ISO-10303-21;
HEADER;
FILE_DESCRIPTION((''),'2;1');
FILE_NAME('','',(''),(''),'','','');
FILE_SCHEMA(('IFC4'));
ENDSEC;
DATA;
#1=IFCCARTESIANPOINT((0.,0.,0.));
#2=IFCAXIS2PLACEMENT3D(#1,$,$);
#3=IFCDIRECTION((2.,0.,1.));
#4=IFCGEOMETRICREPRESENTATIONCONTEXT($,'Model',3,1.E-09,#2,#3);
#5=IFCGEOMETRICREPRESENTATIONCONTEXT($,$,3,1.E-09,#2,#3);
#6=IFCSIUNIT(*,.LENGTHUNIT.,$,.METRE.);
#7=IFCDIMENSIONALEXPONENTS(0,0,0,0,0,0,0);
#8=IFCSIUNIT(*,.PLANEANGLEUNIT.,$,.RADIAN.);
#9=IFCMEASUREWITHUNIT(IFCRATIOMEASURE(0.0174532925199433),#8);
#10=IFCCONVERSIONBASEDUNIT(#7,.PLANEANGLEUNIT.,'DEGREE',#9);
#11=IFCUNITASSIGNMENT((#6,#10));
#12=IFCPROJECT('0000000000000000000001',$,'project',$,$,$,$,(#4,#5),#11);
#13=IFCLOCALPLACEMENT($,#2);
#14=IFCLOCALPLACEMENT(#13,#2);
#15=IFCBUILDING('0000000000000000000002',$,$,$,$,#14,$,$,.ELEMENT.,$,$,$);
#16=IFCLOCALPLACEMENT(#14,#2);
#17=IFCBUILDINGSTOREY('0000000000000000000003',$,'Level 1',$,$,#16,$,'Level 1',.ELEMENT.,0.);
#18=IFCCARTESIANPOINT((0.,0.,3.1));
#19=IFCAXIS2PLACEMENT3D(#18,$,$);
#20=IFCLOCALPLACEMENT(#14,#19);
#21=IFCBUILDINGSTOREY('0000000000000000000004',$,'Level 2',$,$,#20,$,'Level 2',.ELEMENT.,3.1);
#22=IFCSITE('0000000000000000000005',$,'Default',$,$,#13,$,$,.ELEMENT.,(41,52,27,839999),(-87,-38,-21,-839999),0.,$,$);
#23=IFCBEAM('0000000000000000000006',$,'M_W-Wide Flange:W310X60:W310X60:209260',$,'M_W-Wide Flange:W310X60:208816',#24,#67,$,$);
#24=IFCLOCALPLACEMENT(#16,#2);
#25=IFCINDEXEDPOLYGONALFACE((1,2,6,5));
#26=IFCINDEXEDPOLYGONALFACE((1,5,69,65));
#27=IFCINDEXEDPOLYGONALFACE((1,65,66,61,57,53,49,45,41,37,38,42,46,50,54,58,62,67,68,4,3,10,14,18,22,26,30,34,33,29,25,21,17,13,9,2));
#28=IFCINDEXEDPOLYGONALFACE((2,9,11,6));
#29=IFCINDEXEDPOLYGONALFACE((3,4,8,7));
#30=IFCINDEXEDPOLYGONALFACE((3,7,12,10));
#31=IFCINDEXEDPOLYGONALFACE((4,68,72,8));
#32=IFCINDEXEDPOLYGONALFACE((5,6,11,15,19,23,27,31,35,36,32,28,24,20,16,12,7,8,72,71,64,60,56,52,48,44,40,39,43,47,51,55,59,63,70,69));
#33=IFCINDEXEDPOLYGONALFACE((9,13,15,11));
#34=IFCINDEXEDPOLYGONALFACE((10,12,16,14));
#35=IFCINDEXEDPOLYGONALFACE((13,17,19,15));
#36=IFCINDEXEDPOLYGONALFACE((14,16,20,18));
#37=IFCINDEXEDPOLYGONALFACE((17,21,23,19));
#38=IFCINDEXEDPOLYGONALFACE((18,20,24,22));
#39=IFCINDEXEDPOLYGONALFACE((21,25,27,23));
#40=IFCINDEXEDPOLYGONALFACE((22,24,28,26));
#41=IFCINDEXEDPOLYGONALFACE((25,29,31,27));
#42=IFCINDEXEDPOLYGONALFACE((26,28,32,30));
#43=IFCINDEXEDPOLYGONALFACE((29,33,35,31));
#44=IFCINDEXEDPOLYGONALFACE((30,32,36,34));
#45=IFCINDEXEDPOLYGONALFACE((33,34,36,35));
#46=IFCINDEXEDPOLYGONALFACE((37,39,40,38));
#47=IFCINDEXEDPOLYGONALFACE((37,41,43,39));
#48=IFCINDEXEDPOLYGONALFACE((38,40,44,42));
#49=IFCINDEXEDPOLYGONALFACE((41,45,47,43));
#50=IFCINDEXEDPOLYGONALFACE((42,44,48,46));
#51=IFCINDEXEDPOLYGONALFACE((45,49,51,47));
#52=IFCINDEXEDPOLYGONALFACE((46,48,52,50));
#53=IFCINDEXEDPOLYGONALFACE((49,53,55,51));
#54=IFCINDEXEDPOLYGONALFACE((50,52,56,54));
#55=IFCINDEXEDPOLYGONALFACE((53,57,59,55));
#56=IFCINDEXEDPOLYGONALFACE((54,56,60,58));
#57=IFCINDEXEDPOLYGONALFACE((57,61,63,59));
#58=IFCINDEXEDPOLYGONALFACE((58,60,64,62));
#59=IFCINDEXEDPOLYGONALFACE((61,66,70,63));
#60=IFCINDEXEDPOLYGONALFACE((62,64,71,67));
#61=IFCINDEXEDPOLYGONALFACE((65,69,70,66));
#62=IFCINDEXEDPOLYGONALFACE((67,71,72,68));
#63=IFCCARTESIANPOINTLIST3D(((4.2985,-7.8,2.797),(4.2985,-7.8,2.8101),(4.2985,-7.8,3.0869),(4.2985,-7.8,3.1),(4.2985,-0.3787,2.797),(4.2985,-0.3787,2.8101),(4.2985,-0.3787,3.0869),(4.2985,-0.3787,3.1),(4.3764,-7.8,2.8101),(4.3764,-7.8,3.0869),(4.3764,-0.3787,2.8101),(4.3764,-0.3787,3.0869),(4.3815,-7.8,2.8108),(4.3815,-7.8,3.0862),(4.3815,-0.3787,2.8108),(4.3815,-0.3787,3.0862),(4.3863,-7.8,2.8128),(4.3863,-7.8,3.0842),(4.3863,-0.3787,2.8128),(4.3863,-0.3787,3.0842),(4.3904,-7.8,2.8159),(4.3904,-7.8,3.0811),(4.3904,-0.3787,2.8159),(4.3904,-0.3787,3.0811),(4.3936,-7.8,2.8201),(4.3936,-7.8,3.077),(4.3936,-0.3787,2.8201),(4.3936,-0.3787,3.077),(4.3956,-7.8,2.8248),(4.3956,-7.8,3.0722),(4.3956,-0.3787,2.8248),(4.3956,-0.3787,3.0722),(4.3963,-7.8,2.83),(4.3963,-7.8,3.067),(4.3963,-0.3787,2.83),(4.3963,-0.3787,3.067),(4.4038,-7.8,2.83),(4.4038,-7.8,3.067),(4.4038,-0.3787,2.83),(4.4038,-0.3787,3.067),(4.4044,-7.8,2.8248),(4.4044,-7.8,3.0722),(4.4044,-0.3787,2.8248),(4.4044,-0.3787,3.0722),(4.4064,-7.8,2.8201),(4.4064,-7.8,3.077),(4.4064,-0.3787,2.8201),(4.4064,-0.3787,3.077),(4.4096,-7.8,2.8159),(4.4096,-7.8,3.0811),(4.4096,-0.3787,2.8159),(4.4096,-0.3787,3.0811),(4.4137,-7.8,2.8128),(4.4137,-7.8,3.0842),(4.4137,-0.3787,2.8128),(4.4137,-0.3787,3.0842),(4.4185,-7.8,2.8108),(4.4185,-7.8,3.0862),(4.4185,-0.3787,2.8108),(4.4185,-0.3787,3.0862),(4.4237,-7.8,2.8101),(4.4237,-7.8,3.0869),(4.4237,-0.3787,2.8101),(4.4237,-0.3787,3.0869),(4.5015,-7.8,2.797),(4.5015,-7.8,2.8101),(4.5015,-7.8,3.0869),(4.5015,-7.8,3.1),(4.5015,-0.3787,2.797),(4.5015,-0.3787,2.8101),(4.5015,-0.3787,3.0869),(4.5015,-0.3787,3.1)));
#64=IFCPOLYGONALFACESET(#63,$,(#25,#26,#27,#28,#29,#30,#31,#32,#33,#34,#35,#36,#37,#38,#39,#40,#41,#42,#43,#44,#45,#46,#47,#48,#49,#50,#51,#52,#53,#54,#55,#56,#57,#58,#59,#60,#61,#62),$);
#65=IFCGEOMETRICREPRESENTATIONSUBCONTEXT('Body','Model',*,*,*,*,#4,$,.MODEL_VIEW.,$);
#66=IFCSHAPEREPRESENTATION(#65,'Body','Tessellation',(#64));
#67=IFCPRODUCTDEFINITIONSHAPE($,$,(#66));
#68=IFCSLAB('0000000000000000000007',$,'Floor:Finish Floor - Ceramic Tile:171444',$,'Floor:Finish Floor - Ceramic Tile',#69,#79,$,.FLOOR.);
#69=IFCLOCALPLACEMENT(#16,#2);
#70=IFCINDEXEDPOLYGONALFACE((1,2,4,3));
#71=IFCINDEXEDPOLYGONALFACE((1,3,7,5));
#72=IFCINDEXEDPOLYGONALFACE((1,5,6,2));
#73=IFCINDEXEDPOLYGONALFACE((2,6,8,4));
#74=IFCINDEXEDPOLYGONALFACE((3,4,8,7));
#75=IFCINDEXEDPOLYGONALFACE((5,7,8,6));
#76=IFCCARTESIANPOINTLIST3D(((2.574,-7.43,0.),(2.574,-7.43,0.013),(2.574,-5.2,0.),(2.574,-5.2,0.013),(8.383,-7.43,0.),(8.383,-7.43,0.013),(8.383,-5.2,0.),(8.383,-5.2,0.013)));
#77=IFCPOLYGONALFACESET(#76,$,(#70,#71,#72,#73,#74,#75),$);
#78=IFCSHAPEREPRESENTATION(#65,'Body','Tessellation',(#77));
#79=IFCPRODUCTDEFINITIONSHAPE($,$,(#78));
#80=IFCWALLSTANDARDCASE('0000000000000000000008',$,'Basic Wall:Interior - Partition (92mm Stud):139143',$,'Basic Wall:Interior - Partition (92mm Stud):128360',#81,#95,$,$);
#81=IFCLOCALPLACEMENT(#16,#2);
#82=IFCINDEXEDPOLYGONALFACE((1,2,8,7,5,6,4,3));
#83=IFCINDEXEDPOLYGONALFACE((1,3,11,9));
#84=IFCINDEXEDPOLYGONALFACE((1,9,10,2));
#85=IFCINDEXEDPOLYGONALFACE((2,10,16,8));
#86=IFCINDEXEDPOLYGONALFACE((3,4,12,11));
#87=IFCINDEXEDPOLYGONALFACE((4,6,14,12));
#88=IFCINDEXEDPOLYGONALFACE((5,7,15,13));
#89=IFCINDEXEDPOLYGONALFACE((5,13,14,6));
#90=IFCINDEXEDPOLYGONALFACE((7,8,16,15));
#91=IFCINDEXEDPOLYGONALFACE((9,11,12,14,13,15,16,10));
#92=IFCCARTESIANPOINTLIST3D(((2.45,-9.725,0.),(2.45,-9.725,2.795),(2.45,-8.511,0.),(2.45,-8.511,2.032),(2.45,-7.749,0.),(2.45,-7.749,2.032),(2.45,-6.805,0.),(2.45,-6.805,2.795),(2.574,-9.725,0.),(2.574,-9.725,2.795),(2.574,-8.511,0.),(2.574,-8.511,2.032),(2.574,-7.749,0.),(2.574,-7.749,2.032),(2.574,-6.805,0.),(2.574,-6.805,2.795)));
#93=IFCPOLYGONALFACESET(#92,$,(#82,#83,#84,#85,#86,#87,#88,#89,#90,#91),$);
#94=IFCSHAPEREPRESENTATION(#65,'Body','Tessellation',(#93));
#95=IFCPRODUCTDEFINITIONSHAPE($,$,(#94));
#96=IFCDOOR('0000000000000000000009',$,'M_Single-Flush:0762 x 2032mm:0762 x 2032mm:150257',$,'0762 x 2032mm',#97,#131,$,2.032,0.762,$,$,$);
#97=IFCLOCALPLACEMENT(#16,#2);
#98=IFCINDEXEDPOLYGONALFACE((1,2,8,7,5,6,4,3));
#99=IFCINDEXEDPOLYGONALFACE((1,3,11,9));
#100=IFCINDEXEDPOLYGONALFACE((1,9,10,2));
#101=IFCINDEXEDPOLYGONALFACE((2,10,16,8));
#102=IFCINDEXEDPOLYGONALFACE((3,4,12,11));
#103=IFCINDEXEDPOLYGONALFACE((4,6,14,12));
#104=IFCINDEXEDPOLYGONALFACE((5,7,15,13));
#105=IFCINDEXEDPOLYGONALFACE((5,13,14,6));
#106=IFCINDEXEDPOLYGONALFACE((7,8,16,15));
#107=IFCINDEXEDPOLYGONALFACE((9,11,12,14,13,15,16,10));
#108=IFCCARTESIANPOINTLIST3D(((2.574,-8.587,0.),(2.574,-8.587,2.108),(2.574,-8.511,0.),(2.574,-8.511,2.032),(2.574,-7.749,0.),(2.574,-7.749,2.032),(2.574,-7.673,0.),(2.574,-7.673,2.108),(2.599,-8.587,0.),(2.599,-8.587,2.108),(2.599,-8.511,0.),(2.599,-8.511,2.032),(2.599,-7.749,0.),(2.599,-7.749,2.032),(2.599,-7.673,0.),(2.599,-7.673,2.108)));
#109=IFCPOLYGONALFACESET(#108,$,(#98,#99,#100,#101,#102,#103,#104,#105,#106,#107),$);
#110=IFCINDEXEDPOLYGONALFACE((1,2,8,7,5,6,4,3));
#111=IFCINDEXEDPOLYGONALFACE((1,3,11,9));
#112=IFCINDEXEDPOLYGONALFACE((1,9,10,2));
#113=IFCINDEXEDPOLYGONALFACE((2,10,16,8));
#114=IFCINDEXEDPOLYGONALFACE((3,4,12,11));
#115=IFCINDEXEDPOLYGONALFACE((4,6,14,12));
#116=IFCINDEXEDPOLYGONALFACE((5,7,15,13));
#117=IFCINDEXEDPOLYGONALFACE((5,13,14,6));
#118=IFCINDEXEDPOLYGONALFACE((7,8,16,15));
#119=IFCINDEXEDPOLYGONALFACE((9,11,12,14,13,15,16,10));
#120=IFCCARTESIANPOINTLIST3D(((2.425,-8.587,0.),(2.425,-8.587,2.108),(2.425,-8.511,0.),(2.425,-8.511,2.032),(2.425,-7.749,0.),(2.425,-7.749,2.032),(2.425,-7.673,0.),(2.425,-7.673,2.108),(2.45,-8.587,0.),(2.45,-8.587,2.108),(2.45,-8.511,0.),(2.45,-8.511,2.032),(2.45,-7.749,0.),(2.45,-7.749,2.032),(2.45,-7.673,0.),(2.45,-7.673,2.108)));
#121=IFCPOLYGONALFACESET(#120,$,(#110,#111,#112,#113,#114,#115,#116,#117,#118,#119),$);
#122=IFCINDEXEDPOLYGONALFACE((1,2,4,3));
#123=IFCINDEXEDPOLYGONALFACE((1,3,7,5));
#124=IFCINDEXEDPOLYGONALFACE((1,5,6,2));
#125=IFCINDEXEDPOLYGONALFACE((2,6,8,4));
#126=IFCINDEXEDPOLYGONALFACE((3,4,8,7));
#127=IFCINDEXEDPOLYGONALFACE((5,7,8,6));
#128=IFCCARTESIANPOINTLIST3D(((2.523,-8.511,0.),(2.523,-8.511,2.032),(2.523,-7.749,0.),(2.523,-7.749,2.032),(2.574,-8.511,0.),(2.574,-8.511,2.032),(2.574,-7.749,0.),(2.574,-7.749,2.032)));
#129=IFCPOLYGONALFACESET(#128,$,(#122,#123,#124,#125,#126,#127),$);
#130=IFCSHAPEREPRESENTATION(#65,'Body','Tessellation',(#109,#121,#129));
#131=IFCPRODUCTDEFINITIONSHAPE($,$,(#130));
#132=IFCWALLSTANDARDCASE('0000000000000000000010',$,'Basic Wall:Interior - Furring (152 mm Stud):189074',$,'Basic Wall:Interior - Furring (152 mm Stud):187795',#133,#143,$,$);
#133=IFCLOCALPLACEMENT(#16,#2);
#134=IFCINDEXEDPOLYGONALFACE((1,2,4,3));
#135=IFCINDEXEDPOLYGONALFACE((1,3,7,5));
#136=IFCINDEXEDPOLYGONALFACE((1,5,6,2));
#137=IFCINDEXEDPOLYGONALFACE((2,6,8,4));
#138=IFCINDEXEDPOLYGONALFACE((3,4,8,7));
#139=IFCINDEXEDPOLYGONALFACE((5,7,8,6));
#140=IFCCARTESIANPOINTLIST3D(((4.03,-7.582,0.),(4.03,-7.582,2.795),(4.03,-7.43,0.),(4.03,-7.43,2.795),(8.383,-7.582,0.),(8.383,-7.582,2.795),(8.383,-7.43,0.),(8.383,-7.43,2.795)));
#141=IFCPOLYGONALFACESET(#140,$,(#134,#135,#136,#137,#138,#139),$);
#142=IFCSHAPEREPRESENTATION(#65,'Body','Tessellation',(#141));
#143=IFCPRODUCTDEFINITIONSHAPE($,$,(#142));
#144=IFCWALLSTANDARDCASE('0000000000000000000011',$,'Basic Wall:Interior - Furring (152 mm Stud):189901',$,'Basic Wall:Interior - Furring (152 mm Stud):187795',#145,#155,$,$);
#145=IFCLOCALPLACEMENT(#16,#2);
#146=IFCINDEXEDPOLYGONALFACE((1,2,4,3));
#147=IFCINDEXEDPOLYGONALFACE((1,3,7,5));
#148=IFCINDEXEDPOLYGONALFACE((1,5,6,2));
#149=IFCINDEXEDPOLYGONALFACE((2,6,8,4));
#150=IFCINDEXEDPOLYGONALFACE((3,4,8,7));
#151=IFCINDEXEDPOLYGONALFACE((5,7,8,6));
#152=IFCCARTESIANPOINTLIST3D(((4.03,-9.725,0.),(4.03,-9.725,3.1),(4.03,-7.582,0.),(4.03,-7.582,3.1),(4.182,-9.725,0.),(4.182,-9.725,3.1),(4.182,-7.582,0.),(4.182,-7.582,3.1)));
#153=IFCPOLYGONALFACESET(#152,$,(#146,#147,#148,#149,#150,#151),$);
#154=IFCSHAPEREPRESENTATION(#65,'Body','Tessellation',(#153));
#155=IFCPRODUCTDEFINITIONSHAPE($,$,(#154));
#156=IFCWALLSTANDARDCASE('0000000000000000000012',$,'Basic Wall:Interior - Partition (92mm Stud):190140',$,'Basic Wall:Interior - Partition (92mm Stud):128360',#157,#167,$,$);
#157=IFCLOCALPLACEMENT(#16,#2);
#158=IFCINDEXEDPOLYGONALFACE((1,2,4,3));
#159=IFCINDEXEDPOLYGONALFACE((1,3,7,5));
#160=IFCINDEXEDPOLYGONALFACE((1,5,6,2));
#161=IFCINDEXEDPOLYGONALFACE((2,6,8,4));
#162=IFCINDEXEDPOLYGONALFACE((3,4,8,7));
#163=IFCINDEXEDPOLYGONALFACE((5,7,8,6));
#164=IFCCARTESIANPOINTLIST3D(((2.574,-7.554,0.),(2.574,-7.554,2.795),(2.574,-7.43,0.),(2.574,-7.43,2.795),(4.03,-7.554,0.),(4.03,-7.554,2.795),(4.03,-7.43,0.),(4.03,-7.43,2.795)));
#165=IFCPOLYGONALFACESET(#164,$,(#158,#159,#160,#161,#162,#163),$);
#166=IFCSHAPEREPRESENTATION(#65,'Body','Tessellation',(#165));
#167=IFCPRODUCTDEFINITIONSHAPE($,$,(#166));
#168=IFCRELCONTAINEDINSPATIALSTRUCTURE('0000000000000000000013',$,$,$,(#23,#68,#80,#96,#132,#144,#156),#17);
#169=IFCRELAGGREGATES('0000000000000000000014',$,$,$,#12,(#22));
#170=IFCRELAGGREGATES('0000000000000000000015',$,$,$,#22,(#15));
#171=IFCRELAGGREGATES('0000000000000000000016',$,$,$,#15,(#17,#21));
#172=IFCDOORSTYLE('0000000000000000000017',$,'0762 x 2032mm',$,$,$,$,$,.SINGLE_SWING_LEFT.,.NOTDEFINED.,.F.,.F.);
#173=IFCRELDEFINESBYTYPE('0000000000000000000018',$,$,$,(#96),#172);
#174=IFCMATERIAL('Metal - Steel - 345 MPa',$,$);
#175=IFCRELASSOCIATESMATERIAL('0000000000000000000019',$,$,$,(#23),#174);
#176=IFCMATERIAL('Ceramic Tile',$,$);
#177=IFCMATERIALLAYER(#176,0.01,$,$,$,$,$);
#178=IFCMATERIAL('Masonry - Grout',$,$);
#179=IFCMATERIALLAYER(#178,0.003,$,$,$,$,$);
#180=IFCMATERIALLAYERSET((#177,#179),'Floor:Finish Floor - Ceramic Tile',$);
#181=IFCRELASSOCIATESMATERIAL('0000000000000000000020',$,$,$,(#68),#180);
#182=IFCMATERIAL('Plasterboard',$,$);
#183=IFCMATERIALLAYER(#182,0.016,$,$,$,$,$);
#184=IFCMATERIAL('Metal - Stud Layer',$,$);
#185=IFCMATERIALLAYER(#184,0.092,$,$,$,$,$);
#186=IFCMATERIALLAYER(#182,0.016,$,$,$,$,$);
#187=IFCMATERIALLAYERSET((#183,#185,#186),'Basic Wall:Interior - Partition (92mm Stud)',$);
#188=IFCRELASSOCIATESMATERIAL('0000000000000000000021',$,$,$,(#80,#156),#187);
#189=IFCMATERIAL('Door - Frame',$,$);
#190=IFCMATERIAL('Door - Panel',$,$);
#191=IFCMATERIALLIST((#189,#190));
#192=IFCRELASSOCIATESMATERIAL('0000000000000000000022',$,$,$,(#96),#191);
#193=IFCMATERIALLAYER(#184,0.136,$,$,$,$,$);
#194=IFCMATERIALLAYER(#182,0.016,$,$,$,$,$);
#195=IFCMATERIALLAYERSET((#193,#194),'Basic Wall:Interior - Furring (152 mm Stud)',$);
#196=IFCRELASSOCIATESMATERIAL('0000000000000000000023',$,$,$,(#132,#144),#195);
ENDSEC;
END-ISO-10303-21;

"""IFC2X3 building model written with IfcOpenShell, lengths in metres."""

from ifc_helpers import new_model, entity, si_unit, converted_unit, direction, frame, frame_2d, origin, place, context, subcontext, project, spatial, polyline, rectangle, i_section, outline, extrude, clip, bounded_halfspace, source, transform, mapped, material, material_list, layer, layer_set, layer_usage, type_object, type_shapes, element, fill, save


model = new_model("IFC2X3")

# Units and contexts
model_context = context("Model", 3, precision=1e-09, world=origin(), true_north=direction((2.0, 0.0, 1.0)))
context_of_model = context(None, 3, precision=1e-09, world=origin(), true_north=direction((2.0, 0.0, 1.0)))
body_context = subcontext(model_context, "Body", "Model", "MODEL_VIEW")
ifc_project = project(units=[si_unit("LENGTHUNIT", "METRE"), converted_unit("PLANEANGLEUNIT", "DEGREE", entity("IfcRatioMeasure", 0.0174532925199433), si_unit("PLANEANGLEUNIT", "RADIAN"), dimensions=[0, 0, 0, 0, 0, 0, 0])], contexts=[model_context, context_of_model])

# Site, building, storey
site_placement = place(None, origin())
site = spatial("IfcSite", under=ifc_project, at=site_placement, Name="Default", CompositionType="ELEMENT", RefLatitude=(41, 52, 27, 839999), RefLongitude=(-87, -38, -21, -839999), RefElevation=0.0)
building_placement = place(site_placement, origin())
building = spatial("IfcBuilding", under=site, at=building_placement, CompositionType="ELEMENT")
storey_1_placement = place(building_placement, origin())
storey_1 = spatial("IfcBuildingStorey", under=building, at=storey_1_placement, Name="Level 1", LongName="Level 1", CompositionType="ELEMENT", Elevation=0.0)

# Beam
ifc_material_1 = material(Name="Metal - Steel - 345 MPa")
beam_placement = place(storey_1_placement, frame((4.4, -7.8, 3.1), z_axis=(0.0, 0.0, 1.0), x_axis=(0.0, 1.0, 0.0)))
element("IfcBeam", 1, at=beam_placement, inside=storey_1, material=ifc_material_1, Name="M_W-Wide Flange:W310X60:W310X60:209260", ObjectType="M_W-Wide Flange:W310X60:208816", context=body_context, shape_type="SweptSolid", body=[
    extrude(i_section(OverallWidth=0.203, OverallDepth=0.303, WebThickness=0.0075, FlangeThickness=0.0131, FilletRadius=0.0199, at=frame_2d((0.0, 0.0), x_axis=(1.0, 0.0))), frame((0.0, 0.0, -0.1515), z_axis=(-1.0, 0.0, 0.0), x_axis=(0.0, -1.0, 0.0)), (0.0, 0.0, -1.0), 7.4213),
])

# Slab
ifc_material_2 = material(Name="Ceramic Tile")
ifc_layer_1 = layer(ifc_material_2, 0.01)
ifc_material_3 = material(Name="Masonry - Grout")
ifc_layer_2 = layer(ifc_material_3, 0.003)
ifc_layer_set_1 = layer_set([ifc_layer_1, ifc_layer_2], Name="Floor:Finish Floor - Ceramic Tile")
ifc_layer_usage_1 = layer_usage(ifc_layer_set_1, "AXIS3", "POSITIVE", 0.0)
slab_placement = place(storey_1_placement, frame((2.574, -7.43, 0.0)))
element("IfcSlab", 2, at=slab_placement, inside=storey_1, material=ifc_layer_usage_1, Name="Floor:Finish Floor - Ceramic Tile:171444", ObjectType="Floor:Finish Floor - Ceramic Tile", PredefinedType="FLOOR", context=body_context, shape_type="SweptSolid", body=[
    extrude(rectangle(XDim=5.809, YDim=2.23, at=frame_2d((0.0, 0.0), x_axis=(-1.0, 0.0))), frame((2.9045, 1.115, 0.013), z_axis=(0.0, 0.0, -1.0), x_axis=(-1.0, 0.0, 0.0)), (0.0, 0.0, 1.0), 0.013),
])

# Wall, opening, door
ifc_material_4 = material(Name="Plasterboard")
ifc_layer_3 = layer(ifc_material_4, 0.016)
ifc_material_5 = material(Name="Metal - Stud Layer")
ifc_layer_4 = layer(ifc_material_5, 0.092)
ifc_layer_5 = layer(ifc_material_4, 0.016)
ifc_layer_set_2 = layer_set([ifc_layer_3, ifc_layer_4, ifc_layer_5], Name="Basic Wall:Interior - Partition (92mm Stud)")
ifc_layer_usage_2 = layer_usage(ifc_layer_set_2, "AXIS2", "NEGATIVE", 0.062)
wall_1_placement = place(storey_1_placement, frame((2.512, -6.805, 0.0), z_axis=(0.0, 0.0, 1.0), x_axis=(0.0, -1.0, 0.0)))
wall_1 = element("IfcWallStandardCase", 3, at=wall_1_placement, inside=storey_1, material=ifc_layer_usage_2, Name="Basic Wall:Interior - Partition (92mm Stud):139143", ObjectType="Basic Wall:Interior - Partition (92mm Stud):128360", context=body_context, shape_type="SweptSolid", body=[
    extrude(rectangle(XDim=2.92, YDim=0.124, at=frame_2d((1.46, 0.0), x_axis=(-1.0, 0.0))), origin(), (0.0, 0.0, 1.0), 2.795),
])
opening_1_placement = place(wall_1_placement, frame((0.944, -0.062, 0.0)))
opening_1 = element("IfcOpeningElement", 4, at=opening_1_placement, cuts=wall_1, ObjectType="Opening", context=body_context, shape_type="SweptSolid", body=[
    extrude(rectangle(XDim=0.762, YDim=2.032, at=frame_2d((1.016, 0.381), x_axis=(0.0, -1.0))), frame((0.0, 0.0, 0.0), z_axis=(0.0, 1.0, 0.0), x_axis=(0.0, 0.0, 1.0)), (0.0, 0.0, 1.0), 0.124),
])
ifc_material_6 = material(Name="Door - Frame")
ifc_material_7 = material(Name="Door - Panel")
ifc_material_list_1 = material_list([ifc_material_6, ifc_material_7])
door_style_1 = type_object("IfcDoorStyle", Name="0762 x 2032mm", ConstructionType="NOTDEFINED", OperationType="SINGLE_SWING_LEFT", ParameterTakesPrecedence=False, Sizeable=False)
shared_shape_1 = source(origin(), body_context, "Body", "SweptSolid", [
    extrude(outline(polyline([(-0.457, -1.073), (0.457, -1.073), (0.457, 1.035), (0.381, 1.035), (0.381, -0.997), (-0.381, -0.997), (-0.381, 1.035), (-0.457, 1.035), (-0.457, -1.073)])), frame((0.381, 0.149, 1.035), z_axis=(0.0, -1.0, 0.0), x_axis=(-1.0, 0.0, 0.0)), (0.0, 0.0, 1.0), 0.025),
    extrude(outline(polyline([(-1.073, -0.457), (1.035, -0.457), (1.035, -0.381), (-0.997, -0.381), (-0.997, 0.381), (1.035, 0.381), (1.035, 0.457), (-1.073, 0.457), (-1.073, -0.457)])), frame((0.381, 0.0, 1.035), z_axis=(0.0, -1.0, 0.0), x_axis=(0.0, 0.0, -1.0)), (0.0, 0.0, 1.0), 0.025),
    extrude(rectangle(XDim=0.762, YDim=0.051, at=frame_2d((0.0, 0.0), x_axis=(1.0, 0.0))), frame((0.381, 0.0985, 0.0)), (0.0, 0.0, 1.0), 2.032),
])
type_shapes(door_style_1, [shared_shape_1])
door_1_placement = place(opening_1_placement, origin())
door_1 = element("IfcDoor", 5, at=door_1_placement, inside=storey_1, type_object=door_style_1, material=ifc_material_list_1, Name="M_Single-Flush:0762 x 2032mm:0762 x 2032mm:150257", ObjectType="0762 x 2032mm", OverallHeight=2.032, OverallWidth=0.762, context=body_context, shape_type="MappedRepresentation", body=[
    mapped(shared_shape_1, transform((0.0, 0.0, 0.0), scale=1.0)),
])
fill(opening_1, door_1)

# Shared definitions
storey_2_placement = place(building_placement, frame((0.0, 0.0, 3.1)))
storey_2 = spatial("IfcBuildingStorey", under=building, at=storey_2_placement, Name="Level 2", LongName="Level 2", CompositionType="ELEMENT", Elevation=3.1)

# Walls
ifc_layer_6 = layer(ifc_material_5, 0.136)
ifc_layer_7 = layer(ifc_material_4, 0.016)
ifc_layer_set_3 = layer_set([ifc_layer_6, ifc_layer_7], Name="Basic Wall:Interior - Furring (152 mm Stud)")
ifc_layer_usage_3 = layer_usage(ifc_layer_set_3, "AXIS2", "NEGATIVE", 0.076)
wall_2_placement = place(storey_1_placement, frame((8.383, -7.506, 0.0), z_axis=(0.0, 0.0, 1.0), x_axis=(-1.0, 0.0, 0.0)))
element("IfcWallStandardCase", 6, at=wall_2_placement, inside=storey_1, material=ifc_layer_usage_3, Name="Basic Wall:Interior - Furring (152 mm Stud):189074", ObjectType="Basic Wall:Interior - Furring (152 mm Stud):187795", context=body_context, shape_type="Clipping", body=[
    clip(extrude(rectangle(XDim=4.353, YDim=0.152, at=frame_2d((2.1765, 0.0), x_axis=(-1.0, 0.0))), origin(), (0.0, 0.0, 1.0), 2.795), bounded_halfspace(frame((0.0, -0.076, 2.795), z_axis=(0.0, 0.0, -1.0), x_axis=(0.0, 1.0, 0.0)), True, frame((0.0, -0.076, 2.795)), polyline([(0.0, 0.0), (3.708, 0.0), (3.708, 0.152), (0.0, 0.152), (0.0, 0.0)]))),
])
ifc_layer_usage_4 = layer_usage(ifc_layer_set_3, "AXIS2", "POSITIVE", -0.076)
wall_3_placement = place(storey_1_placement, frame((4.106, -9.725, 0.0), z_axis=(0.0, 0.0, 1.0), x_axis=(0.0, 1.0, 0.0)))
element("IfcWallStandardCase", 7, at=wall_3_placement, inside=storey_1, material=ifc_layer_usage_4, Name="Basic Wall:Interior - Furring (152 mm Stud):189901", ObjectType="Basic Wall:Interior - Furring (152 mm Stud):187795", context=body_context, shape_type="SweptSolid", body=[
    extrude(rectangle(XDim=2.143, YDim=0.152, at=frame_2d((1.0715, 0.0), x_axis=(-1.0, 0.0))), origin(), (0.0, 0.0, 1.0), 3.1),
])
ifc_layer_usage_5 = layer_usage(ifc_layer_set_2, "AXIS2", "NEGATIVE", 0.062)
wall_4_placement = place(storey_1_placement, frame((4.03, -7.492, 0.0), z_axis=(0.0, 0.0, 1.0), x_axis=(-1.0, 0.0, 0.0)))
element("IfcWallStandardCase", 8, at=wall_4_placement, inside=storey_1, material=ifc_layer_usage_5, Name="Basic Wall:Interior - Partition (92mm Stud):190140", ObjectType="Basic Wall:Interior - Partition (92mm Stud):128360", context=body_context, shape_type="SweptSolid", body=[
    extrude(rectangle(XDim=1.456, YDim=0.124, at=frame_2d((0.728, 0.0), x_axis=(-1.0, 0.0))), origin(), (0.0, 0.0, 1.0), 2.795),
])

save(model, "model.ifc")
